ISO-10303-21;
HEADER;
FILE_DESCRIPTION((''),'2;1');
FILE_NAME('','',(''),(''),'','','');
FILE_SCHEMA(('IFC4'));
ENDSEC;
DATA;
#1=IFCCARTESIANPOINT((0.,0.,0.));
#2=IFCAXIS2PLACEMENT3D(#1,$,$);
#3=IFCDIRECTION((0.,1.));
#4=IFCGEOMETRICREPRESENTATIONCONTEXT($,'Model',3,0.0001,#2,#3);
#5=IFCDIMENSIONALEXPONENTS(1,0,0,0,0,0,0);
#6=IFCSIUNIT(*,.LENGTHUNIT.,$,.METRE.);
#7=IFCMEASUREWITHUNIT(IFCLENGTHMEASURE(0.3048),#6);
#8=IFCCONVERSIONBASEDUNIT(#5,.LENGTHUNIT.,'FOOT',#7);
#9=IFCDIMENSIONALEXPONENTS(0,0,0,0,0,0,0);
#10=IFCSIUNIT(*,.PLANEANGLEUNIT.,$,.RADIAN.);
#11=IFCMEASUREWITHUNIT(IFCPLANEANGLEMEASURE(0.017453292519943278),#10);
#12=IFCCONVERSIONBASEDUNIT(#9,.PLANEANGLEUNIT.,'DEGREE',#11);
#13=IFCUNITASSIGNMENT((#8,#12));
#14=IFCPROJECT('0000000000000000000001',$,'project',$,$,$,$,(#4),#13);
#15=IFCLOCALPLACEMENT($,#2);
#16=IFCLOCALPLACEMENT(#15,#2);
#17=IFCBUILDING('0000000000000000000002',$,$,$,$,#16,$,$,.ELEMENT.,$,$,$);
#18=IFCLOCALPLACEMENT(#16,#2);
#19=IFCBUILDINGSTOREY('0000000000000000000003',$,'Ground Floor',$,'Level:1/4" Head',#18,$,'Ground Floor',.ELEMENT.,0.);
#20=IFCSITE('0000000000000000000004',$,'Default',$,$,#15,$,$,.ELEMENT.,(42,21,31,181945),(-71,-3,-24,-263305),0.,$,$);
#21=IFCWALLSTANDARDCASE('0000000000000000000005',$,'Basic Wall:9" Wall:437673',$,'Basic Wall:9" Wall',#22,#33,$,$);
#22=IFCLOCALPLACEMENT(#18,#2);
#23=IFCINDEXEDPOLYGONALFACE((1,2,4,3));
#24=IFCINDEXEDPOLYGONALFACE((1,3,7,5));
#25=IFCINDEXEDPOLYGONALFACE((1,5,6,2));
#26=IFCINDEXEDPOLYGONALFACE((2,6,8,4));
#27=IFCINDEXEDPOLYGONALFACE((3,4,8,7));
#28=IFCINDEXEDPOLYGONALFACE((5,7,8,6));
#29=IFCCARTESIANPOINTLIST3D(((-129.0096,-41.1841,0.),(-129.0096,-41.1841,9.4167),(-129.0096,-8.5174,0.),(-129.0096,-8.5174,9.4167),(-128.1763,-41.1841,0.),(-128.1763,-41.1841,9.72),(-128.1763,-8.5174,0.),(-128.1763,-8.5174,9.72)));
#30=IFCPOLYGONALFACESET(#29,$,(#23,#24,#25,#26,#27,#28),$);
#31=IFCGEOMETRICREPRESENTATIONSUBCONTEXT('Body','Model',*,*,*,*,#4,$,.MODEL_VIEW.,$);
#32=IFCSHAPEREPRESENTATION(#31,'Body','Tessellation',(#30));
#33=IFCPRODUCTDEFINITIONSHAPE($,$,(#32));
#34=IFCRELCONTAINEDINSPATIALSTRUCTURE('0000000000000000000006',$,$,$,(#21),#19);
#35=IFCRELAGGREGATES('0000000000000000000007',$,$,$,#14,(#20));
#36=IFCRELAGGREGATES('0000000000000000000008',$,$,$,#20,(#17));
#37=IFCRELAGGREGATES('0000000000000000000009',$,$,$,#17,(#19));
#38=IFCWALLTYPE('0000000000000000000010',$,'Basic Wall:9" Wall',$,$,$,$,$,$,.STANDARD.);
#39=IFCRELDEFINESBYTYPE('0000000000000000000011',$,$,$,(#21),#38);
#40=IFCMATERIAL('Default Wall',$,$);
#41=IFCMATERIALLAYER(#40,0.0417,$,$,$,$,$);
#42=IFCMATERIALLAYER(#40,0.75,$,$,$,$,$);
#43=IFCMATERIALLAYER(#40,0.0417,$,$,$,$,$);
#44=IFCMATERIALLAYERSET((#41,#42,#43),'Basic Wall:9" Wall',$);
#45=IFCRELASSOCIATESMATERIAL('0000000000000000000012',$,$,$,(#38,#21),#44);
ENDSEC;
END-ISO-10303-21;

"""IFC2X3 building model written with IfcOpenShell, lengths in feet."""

from ifc_helpers import new_model, entity, si_unit, converted_unit, direction, frame, frame_2d, origin, place, context, subcontext, project, spatial, polyline, rectangle, extrude, clip, bounded_halfspace, material, layer, layer_set, layer_usage, type_object, element, save


model = new_model("IFC2X3")

# Units and contexts
model_context = context("Model", 3, precision=0.0001, world=origin(), true_north=direction((0.0, 1.0)))
body_context = subcontext(model_context, "Body", "Model", "MODEL_VIEW")
ifc_project = project(units=[converted_unit("LENGTHUNIT", "FOOT", entity("IfcLengthMeasure", 0.3048), si_unit("LENGTHUNIT", "METRE"), dimensions=[1, 0, 0, 0, 0, 0, 0]), converted_unit("PLANEANGLEUNIT", "DEGREE", entity("IfcPlaneAngleMeasure", 0.017453292519943278), si_unit("PLANEANGLEUNIT", "RADIAN"), dimensions=[0, 0, 0, 0, 0, 0, 0])], contexts=[model_context])

# Site, building, storey
site_placement = place(None, origin())
site = spatial("IfcSite", under=ifc_project, at=site_placement, Name="Default", CompositionType="ELEMENT", RefLatitude=(42, 21, 31, 181945), RefLongitude=(-71, -3, -24, -263305), RefElevation=0.0)
building_placement = place(site_placement, origin())
building = spatial("IfcBuilding", under=site, at=building_placement, CompositionType="ELEMENT")
storey_placement = place(building_placement, origin())
storey = spatial("IfcBuildingStorey", under=building, at=storey_placement, Name="Ground Floor", ObjectType="Level:1/4\" Head", LongName="Ground Floor", CompositionType="ELEMENT", Elevation=0.0)

# Wall
ifc_material_1 = material(Name="Default Wall")
ifc_layer_1 = layer(ifc_material_1, 0.0417)
ifc_layer_2 = layer(ifc_material_1, 0.75)
ifc_layer_3 = layer(ifc_material_1, 0.0417)
ifc_layer_set = layer_set([ifc_layer_1, ifc_layer_2, ifc_layer_3], Name="Basic Wall:9\" Wall")
ifc_layer_usage = layer_usage(ifc_layer_set, "AXIS2", "NEGATIVE", 0.4167)
wall_type = type_object("IfcWallType", Name="Basic Wall:9\" Wall", PredefinedType="STANDARD", material=ifc_layer_set)
wall_1_placement = place(storey_placement, frame((-128.593, -41.1841, 0.0), z_axis=(0.0, 0.0, 1.0), x_axis=(0.0, 1.0, 0.0)))
element("IfcWallStandardCase", 1, at=wall_1_placement, inside=storey, type_object=wall_type, material=ifc_layer_usage, Name="Basic Wall:9\" Wall:437673", ObjectType="Basic Wall:9\" Wall", context=body_context, shape_type="Clipping", body=[
    clip(extrude(rectangle(XDim=32.6667, YDim=0.8333, at=frame_2d((16.3333, 0.0), x_axis=(-1.0, 0.0))), origin(), (0.0, 0.0, 1.0), 9.72), bounded_halfspace(frame((0.0, -0.4167, 9.72), z_axis=(0.0, 0.34202, 0.939693), x_axis=(-1.0, 0.0, 0.0)), False, frame((0.0, -0.4167, 9.72)), polyline([(0.0, 0.0), (32.6667, 0.0), (32.6667, 0.8333), (0.0, 0.8333), (0.0, 0.0)]))),
])

save(model, "model.ifc")
